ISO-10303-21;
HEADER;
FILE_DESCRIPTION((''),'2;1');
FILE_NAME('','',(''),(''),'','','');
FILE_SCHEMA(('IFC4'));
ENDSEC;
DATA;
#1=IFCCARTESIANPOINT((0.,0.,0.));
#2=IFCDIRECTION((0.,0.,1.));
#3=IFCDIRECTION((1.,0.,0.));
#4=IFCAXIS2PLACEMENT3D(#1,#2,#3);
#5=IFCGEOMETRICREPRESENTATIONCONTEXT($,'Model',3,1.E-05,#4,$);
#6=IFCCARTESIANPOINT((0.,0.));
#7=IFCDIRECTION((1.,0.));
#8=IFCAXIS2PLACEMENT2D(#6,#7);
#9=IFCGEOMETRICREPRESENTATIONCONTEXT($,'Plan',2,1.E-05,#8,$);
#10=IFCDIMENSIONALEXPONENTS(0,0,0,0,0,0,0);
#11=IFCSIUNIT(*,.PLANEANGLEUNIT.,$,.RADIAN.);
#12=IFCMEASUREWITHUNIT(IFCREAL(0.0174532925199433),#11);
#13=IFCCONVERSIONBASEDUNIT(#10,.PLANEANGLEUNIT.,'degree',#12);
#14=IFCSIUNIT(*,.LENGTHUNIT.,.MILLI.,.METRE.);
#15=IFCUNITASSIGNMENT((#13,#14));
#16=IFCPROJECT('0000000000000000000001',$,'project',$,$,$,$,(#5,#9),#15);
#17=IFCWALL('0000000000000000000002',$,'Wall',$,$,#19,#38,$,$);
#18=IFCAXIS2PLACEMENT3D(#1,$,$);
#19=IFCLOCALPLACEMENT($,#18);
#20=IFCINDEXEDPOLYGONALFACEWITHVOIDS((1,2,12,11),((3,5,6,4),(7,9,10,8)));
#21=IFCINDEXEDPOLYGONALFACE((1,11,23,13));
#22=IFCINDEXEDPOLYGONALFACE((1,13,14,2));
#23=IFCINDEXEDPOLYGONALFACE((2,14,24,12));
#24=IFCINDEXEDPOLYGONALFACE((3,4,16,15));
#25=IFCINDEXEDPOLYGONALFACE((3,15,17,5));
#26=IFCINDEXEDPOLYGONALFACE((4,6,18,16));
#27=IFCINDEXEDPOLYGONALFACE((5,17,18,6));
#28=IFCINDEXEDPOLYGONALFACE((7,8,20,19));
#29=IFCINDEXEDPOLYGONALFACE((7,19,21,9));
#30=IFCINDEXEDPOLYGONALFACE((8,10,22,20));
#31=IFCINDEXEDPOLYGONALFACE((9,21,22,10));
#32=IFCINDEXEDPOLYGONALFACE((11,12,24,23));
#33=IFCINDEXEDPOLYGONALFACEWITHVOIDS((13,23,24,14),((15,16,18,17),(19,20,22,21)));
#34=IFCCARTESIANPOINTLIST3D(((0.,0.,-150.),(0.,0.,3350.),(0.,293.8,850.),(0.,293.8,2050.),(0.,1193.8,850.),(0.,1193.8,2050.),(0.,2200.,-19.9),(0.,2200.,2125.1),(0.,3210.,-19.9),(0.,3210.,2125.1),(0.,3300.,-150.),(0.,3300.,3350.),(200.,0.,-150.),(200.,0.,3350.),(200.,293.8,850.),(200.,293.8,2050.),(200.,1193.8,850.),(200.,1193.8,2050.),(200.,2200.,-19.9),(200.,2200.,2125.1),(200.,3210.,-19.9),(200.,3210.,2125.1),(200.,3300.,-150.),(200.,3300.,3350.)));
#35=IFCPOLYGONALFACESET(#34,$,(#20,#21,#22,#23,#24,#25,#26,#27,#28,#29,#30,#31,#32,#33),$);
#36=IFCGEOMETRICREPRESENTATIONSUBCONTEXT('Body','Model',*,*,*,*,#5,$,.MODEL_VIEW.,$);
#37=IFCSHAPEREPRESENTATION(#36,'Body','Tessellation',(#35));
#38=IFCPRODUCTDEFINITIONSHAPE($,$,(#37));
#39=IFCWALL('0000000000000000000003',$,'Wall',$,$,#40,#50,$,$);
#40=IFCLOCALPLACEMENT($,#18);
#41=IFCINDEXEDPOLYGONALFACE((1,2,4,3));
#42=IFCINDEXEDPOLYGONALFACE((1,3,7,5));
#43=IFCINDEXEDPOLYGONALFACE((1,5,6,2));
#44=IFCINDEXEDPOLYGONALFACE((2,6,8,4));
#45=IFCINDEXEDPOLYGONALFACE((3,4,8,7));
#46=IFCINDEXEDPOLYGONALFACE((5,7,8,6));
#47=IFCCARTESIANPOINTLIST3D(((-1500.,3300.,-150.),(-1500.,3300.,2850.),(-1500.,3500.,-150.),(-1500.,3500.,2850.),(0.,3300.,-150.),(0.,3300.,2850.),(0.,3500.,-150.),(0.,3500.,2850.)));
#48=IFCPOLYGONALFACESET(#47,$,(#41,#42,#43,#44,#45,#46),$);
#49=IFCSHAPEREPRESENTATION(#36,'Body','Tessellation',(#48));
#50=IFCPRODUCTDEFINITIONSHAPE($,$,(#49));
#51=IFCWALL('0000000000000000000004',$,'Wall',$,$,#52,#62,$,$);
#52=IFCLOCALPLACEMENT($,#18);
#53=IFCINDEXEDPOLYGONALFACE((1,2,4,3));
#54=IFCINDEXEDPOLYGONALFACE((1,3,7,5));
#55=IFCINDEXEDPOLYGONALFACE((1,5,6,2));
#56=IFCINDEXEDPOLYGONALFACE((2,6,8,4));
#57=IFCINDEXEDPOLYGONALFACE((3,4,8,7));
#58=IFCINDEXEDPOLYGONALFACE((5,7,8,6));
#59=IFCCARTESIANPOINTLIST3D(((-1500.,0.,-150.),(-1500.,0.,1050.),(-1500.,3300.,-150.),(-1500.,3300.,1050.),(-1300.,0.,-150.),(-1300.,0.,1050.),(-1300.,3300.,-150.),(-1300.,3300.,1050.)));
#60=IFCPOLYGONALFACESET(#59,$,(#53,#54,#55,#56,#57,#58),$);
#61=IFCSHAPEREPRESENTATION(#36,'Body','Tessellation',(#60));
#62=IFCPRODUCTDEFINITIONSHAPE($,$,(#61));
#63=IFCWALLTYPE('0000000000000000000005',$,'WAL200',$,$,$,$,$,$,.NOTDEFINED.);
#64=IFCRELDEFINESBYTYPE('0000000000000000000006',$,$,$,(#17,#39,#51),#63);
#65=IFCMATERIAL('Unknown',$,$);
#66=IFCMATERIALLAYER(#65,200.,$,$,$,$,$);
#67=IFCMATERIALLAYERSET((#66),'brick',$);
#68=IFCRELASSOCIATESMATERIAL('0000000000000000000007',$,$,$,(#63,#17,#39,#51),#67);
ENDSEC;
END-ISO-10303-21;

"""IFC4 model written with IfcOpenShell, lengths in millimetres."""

from ifc_helpers import new_model, entity, si_unit, converted_unit, frame, origin_with_axes, origin_2d_with_axis, place, context, subcontext, project, line, indexed_curve, outline, extrude, source, transform, mapped, material, layer, layer_set, layer_usage, type_object, element, save


model = new_model("IFC4")

# Units and contexts
model_context = context("Model", 3, precision=1e-05, world=origin_with_axes())
plan_context = context("Plan", 2, precision=1e-05, world=origin_2d_with_axis())
body_context = subcontext(model_context, "Body", "Model", "MODEL_VIEW")
ifc_project = project(units=[converted_unit("PLANEANGLEUNIT", "degree", entity("IfcReal", 0.0174532925199433), si_unit("PLANEANGLEUNIT", "RADIAN"), dimensions=[0, 0, 0, 0, 0, 0, 0]), si_unit("LENGTHUNIT", "METRE", prefix="MILLI")], contexts=[model_context, plan_context])

# Shared definitions
ifc_material = material(Name="Unknown")
placement = place(None, frame((0.0, 0.0, -150.0), z_axis=(0.0, 0.0, 1.0), x_axis=(1.0, 0.0, 0.0)))

# Shared definitions
ifc_layer_1 = layer(ifc_material, 200.0)
ifc_layer_set_1 = layer_set([ifc_layer_1], Name="brick")
wall_type_1 = type_object("IfcWallType", Name="WAL200", PredefinedType="NOTDEFINED", material=ifc_layer_set_1)

# Shared definitions
shared_shape_1 = source(origin_with_axes(), body_context, "Body", "SweptSolid", [
    extrude(outline(indexed_curve([(0.0, 0.0), (900.0, 0.0), (900.0, 1200.0), (0.0, 1200.0)], segments=[line(1, 2, 3, 4, 1)])), frame((0.0, -600.0, 0.0), z_axis=(0.0, -1.0, 0.0), x_axis=(1.0, 0.0, 0.0)), (0.0, 0.0, -1.0), 1200.0),
])

# Wall, openings
ifc_layer_usage_1 = layer_usage(ifc_layer_set_1, "AXIS2", "POSITIVE", 0.0)
wall_1_placement = place(placement, frame((0.0, 3300.0, 0.0), z_axis=(0.0, 0.0, 1.0), x_axis=(-0.000001, -1.0, 0.0)))
wall_1 = element("IfcWall", 1, at=wall_1_placement, type_object=wall_type_1, material=ifc_layer_usage_1, Name="Wall", context=body_context, shape_type="SweptSolid", body=[
    extrude(outline(indexed_curve([(0.0, 0.0), (0.0, 200.0), (3300.0, 200.0), (3300.0, 0.0), (0.0, 0.0)], self_intersect=False)), origin_with_axes(), (0.0, 0.0, 1.0), 3500.0),
])
shared_shape_2 = source(origin_with_axes(), body_context, "Body", "SweptSolid", [
    extrude(outline(indexed_curve([(0.0, 0.0), (1010.0, 0.0), (1010.0, 2145.0), (0.0, 2145.0)], segments=[line(1, 2, 3, 4, 1)])), frame((0.0, -600.0, 0.0), z_axis=(0.0, -1.0, 0.0), x_axis=(1.0, 0.0, 0.0)), (0.0, 0.0, -1.0), 1200.0),
])
opening_1_placement = place(wall_1_placement, frame((90.0, 0.0, 130.1), z_axis=(0.0, 0.0, 1.0), x_axis=(1.0, 0.0, 0.0)))
element("IfcOpeningElement", 2, at=opening_1_placement, cuts=wall_1, PredefinedType="OPENING", context=body_context, shape_type="MappedRepresentation", body=[
    mapped(shared_shape_2, transform((0.0, 0.0, 0.0), x_axis=(1.0, 0.0, 0.0), y_axis=(0.0, 1.0, 0.0), z_axis=(0.0, 0.0, 1.0), scale=1.0)),
])
opening_2_placement = place(wall_1_placement, frame((2106.2, 0.0, 1000.0), z_axis=(0.0, 0.0, 1.0), x_axis=(1.0, 0.0, 0.0)))
element("IfcOpeningElement", 3, at=opening_2_placement, cuts=wall_1, PredefinedType="OPENING", context=body_context, shape_type="MappedRepresentation", body=[
    mapped(shared_shape_1, transform((0.0, 0.0, 0.0), x_axis=(1.0, 0.0, 0.0), y_axis=(0.0, 1.0, 0.0), z_axis=(0.0, 0.0, 1.0), scale=1.0)),
])

# Walls
ifc_layer_usage_2 = layer_usage(ifc_layer_set_1, "AXIS2", "POSITIVE", 0.0)
wall_2_placement = place(placement, frame((0.0, 3500.0, 0.0), z_axis=(0.0, 0.0, 1.0), x_axis=(-1.0, 0.0, 0.0)))
element("IfcWall", 4, at=wall_2_placement, type_object=wall_type_1, material=ifc_layer_usage_2, Name="Wall", context=body_context, shape_type="SweptSolid", body=[
    extrude(outline(indexed_curve([(0.0, 0.0), (0.0, 200.0), (1500.0, 200.0), (1500.0, 0.0), (0.0, 0.0)], self_intersect=False)), origin_with_axes(), (0.0, 0.0, 1.0), 3000.0),
])
ifc_layer_usage_3 = layer_usage(ifc_layer_set_1, "AXIS2", "POSITIVE", 0.0)
wall_3_placement = place(placement, frame((-1500.0, 3300.0, 0.0), z_axis=(0.0, 0.0, 1.0), x_axis=(0.0, -1.0, 0.0)))
element("IfcWall", 5, at=wall_3_placement, type_object=wall_type_1, material=ifc_layer_usage_3, Name="Wall", context=body_context, shape_type="SweptSolid", body=[
    extrude(outline(indexed_curve([(0.0, 0.0), (0.0, 200.0), (3300.0, 200.0), (3300.0, 0.0), (0.0, 0.0)], self_intersect=False)), origin_with_axes(), (0.0, 0.0, 1.0), 1200.0),
])

save(model, "model.ifc")
